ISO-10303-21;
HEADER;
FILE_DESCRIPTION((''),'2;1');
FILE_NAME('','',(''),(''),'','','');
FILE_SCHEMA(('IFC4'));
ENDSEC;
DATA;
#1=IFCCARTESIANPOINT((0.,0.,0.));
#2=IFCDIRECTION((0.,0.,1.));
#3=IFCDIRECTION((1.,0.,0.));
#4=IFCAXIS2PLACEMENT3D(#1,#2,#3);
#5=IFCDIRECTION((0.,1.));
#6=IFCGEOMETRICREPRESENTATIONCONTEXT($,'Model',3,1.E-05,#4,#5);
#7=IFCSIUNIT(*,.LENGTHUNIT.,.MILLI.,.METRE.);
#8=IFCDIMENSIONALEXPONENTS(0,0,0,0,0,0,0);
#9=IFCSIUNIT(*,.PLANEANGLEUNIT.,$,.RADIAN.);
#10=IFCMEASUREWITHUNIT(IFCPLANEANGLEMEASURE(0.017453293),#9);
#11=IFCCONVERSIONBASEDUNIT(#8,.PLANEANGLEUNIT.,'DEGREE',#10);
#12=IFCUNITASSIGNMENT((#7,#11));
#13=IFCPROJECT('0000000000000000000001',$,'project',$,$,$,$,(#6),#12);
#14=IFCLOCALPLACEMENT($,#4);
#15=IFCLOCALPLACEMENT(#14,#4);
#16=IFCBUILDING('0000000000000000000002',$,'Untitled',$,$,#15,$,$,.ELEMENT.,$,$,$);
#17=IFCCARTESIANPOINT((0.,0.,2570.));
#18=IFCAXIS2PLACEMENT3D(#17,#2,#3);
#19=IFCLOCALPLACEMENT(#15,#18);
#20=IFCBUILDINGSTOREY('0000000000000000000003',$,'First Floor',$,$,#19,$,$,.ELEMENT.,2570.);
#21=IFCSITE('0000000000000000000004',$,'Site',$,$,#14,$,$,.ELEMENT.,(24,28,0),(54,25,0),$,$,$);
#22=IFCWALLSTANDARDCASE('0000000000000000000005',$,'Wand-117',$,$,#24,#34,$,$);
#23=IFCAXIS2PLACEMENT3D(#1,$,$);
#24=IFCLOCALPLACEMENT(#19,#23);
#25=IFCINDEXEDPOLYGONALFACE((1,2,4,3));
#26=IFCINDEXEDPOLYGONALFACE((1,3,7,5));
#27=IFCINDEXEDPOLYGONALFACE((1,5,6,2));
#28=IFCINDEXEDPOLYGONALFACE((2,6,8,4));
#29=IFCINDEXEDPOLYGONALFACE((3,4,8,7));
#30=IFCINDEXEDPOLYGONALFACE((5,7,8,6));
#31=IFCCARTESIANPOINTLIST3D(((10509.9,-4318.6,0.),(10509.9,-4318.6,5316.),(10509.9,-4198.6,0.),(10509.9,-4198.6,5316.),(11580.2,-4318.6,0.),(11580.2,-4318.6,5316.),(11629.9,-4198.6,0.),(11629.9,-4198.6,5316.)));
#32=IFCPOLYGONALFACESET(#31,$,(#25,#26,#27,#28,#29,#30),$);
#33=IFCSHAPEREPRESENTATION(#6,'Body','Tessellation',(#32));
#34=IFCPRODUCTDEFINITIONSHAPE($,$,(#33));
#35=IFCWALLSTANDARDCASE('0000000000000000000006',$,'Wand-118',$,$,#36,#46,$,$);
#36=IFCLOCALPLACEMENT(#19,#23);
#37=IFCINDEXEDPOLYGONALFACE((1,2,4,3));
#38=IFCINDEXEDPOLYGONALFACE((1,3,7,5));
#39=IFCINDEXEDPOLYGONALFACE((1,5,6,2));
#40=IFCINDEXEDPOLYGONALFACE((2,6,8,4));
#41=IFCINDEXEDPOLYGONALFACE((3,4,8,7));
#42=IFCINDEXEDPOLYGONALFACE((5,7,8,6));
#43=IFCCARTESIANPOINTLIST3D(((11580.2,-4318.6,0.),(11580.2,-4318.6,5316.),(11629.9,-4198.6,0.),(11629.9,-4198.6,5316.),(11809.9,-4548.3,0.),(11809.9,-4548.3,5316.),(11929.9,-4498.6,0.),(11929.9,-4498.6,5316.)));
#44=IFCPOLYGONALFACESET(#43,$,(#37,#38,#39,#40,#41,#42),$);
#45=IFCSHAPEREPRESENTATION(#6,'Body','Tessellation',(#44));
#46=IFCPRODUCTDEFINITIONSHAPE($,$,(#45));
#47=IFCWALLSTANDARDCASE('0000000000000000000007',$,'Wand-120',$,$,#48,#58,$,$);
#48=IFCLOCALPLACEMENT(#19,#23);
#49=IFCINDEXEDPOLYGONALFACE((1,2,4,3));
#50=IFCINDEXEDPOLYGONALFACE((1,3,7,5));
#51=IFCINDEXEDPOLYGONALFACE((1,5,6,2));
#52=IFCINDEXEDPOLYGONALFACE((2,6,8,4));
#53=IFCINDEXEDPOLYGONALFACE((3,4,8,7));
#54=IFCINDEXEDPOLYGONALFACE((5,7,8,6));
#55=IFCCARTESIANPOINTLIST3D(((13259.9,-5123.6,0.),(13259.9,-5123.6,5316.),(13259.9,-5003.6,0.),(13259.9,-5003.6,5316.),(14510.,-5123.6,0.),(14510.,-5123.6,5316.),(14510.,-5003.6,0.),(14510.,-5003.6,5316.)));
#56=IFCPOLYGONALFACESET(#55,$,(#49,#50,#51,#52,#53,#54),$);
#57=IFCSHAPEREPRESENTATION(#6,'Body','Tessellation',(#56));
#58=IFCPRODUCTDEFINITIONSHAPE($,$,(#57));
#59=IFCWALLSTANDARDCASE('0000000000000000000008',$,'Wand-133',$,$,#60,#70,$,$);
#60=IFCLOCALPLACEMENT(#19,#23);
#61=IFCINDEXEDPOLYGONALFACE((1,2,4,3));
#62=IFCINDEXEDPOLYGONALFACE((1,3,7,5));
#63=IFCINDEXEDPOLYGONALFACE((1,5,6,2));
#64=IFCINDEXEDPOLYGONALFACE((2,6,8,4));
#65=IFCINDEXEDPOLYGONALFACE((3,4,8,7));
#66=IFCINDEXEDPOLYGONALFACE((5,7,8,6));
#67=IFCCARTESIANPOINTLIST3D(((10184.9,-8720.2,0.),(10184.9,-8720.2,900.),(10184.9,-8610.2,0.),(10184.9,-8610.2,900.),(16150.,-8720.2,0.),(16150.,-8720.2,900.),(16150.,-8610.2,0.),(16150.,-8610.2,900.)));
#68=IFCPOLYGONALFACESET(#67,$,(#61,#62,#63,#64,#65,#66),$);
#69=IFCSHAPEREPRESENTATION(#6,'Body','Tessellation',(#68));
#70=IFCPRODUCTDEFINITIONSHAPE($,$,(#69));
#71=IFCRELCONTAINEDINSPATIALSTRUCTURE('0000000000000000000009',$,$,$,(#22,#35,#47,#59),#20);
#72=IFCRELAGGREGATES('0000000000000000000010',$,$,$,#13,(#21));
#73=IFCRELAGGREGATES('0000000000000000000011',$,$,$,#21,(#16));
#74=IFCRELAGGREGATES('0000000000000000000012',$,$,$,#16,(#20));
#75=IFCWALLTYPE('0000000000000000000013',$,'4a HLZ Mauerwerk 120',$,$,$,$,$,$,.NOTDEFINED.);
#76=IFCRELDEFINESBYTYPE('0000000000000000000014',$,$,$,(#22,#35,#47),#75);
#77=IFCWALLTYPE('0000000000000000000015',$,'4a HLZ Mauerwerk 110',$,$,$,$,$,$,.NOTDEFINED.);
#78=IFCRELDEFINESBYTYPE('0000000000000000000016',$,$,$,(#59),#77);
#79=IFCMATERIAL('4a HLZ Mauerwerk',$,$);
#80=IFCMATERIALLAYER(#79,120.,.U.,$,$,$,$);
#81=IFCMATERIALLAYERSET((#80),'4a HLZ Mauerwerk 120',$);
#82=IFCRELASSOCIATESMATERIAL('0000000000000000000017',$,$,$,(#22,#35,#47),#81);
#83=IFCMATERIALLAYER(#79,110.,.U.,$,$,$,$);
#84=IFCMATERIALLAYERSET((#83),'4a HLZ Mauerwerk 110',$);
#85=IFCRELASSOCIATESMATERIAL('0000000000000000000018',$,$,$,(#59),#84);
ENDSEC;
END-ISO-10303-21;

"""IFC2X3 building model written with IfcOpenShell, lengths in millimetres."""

from ifc_helpers import new_model, entity, si_unit, converted_unit, direction, frame, origin_with_axes, place, context, project, spatial, polyline, outline, extrude, material, layer, layer_set, layer_usage, type_object, element, save


model = new_model("IFC2X3")

# Units and contexts
model_context = context("Model", 3, precision=1e-05, world=origin_with_axes(), true_north=direction((0.0, 1.0)))
ifc_project = project(units=[si_unit("LENGTHUNIT", "METRE", prefix="MILLI"), converted_unit("PLANEANGLEUNIT", "DEGREE", entity("IfcPlaneAngleMeasure", 0.017453293), si_unit("PLANEANGLEUNIT", "RADIAN"), dimensions=[0, 0, 0, 0, 0, 0, 0])], contexts=[model_context])

# Site, building, storey
site_placement = place(None, origin_with_axes())
site = spatial("IfcSite", under=ifc_project, at=site_placement, Name="Site", CompositionType="ELEMENT", RefLatitude=(24, 28, 0), RefLongitude=(54, 25, 0))
building_placement = place(site_placement, origin_with_axes())
building = spatial("IfcBuilding", under=site, at=building_placement, Name="Untitled", CompositionType="ELEMENT")
storey_placement = place(building_placement, frame((0.0, 0.0, 2570.0), z_axis=(0.0, 0.0, 1.0), x_axis=(1.0, 0.0, 0.0)))
storey = spatial("IfcBuildingStorey", under=building, at=storey_placement, Name="First Floor", CompositionType="ELEMENT", Elevation=2570.0)

# Shared definitions
ifc_material_1 = material(Name="4a HLZ Mauerwerk")

# Shared definitions
ifc_layer_1 = layer(ifc_material_1, 120.0, ventilated="UNKNOWN")
ifc_layer_set_1 = layer_set([ifc_layer_1], Name="4a HLZ Mauerwerk 120")
wall_type_1 = type_object("IfcWallType", Name="4a HLZ Mauerwerk 120", PredefinedType="NOTDEFINED")

# Walls
ifc_layer_usage_1 = layer_usage(ifc_layer_set_1, "AXIS2", "NEGATIVE", 0.0)
wall_1_placement = place(storey_placement, frame((10509.9, -4198.6, 0.0), z_axis=(0.0, 0.0, 1.0), x_axis=(1.0, 0.0, 0.0)))
element("IfcWallStandardCase", 1, at=wall_1_placement, inside=storey, type_object=wall_type_1, material=ifc_layer_usage_1, Name="Wand-117", context=model_context, shape_type="SweptSolid", body=[
    extrude(outline(polyline([(0.0, -120.0), (1070.3, -120.0), (1120.0, 0.0), (0.0, 0.0), (0.0, -120.0)])), origin_with_axes(), (0.0, 0.0, 1.0), 5316.0),
])
ifc_layer_usage_2 = layer_usage(ifc_layer_set_1, "AXIS2", "NEGATIVE", 0.0)
wall_2_placement = place(storey_placement, frame((11629.9, -4198.6, 0.0), z_axis=(0.0, 0.0, 1.0), x_axis=(0.707107, -0.707107, 0.0)))
element("IfcWallStandardCase", 2, at=wall_2_placement, inside=storey, type_object=wall_type_1, material=ifc_layer_usage_2, Name="Wand-118", context=model_context, shape_type="SweptSolid", body=[
    extrude(outline(polyline([(49.7, -120.0), (374.6, -120.0), (424.3, 0.0), (0.0, 0.0), (49.7, -120.0)])), origin_with_axes(), (0.0, 0.0, 1.0), 5316.0),
])

# Walls
ifc_layer_usage_3 = layer_usage(ifc_layer_set_1, "AXIS2", "NEGATIVE", 0.0)
wall_3_placement = place(storey_placement, frame((13259.9, -5003.6, 0.0), z_axis=(0.0, 0.0, 1.0), x_axis=(1.0, 0.0, 0.0)))
element("IfcWallStandardCase", 3, at=wall_3_placement, inside=storey, type_object=wall_type_1, material=ifc_layer_usage_3, Name="Wand-120", context=model_context, shape_type="SweptSolid", body=[
    extrude(outline(polyline([(0.0, -120.0), (1250.0, -120.0), (1250.0, 0.0), (0.0, 0.0), (0.0, -120.0)])), origin_with_axes(), (0.0, 0.0, 1.0), 5316.0),
])
ifc_layer_2 = layer(ifc_material_1, 110.0, ventilated="UNKNOWN")
ifc_layer_set_2 = layer_set([ifc_layer_2], Name="4a HLZ Mauerwerk 110")
ifc_layer_usage_4 = layer_usage(ifc_layer_set_2, "AXIS2", "POSITIVE", 0.0)
wall_type_2 = type_object("IfcWallType", Name="4a HLZ Mauerwerk 110", PredefinedType="NOTDEFINED")
wall_4_placement = place(storey_placement, frame((10184.9, -8720.2, 0.0), z_axis=(0.0, 0.0, 1.0), x_axis=(1.0, 0.0, 0.0)))
element("IfcWallStandardCase", 4, at=wall_4_placement, inside=storey, type_object=wall_type_2, material=ifc_layer_usage_4, Name="Wand-133", context=model_context, shape_type="SweptSolid", body=[
    extrude(outline(polyline([(0.0, 0.0), (5965.1, 0.0), (5965.1, 110.0), (0.0, 110.0), (0.0, 0.0)])), origin_with_axes(), (0.0, 0.0, 1.0), 900.0),
])

save(model, "model.ifc")
